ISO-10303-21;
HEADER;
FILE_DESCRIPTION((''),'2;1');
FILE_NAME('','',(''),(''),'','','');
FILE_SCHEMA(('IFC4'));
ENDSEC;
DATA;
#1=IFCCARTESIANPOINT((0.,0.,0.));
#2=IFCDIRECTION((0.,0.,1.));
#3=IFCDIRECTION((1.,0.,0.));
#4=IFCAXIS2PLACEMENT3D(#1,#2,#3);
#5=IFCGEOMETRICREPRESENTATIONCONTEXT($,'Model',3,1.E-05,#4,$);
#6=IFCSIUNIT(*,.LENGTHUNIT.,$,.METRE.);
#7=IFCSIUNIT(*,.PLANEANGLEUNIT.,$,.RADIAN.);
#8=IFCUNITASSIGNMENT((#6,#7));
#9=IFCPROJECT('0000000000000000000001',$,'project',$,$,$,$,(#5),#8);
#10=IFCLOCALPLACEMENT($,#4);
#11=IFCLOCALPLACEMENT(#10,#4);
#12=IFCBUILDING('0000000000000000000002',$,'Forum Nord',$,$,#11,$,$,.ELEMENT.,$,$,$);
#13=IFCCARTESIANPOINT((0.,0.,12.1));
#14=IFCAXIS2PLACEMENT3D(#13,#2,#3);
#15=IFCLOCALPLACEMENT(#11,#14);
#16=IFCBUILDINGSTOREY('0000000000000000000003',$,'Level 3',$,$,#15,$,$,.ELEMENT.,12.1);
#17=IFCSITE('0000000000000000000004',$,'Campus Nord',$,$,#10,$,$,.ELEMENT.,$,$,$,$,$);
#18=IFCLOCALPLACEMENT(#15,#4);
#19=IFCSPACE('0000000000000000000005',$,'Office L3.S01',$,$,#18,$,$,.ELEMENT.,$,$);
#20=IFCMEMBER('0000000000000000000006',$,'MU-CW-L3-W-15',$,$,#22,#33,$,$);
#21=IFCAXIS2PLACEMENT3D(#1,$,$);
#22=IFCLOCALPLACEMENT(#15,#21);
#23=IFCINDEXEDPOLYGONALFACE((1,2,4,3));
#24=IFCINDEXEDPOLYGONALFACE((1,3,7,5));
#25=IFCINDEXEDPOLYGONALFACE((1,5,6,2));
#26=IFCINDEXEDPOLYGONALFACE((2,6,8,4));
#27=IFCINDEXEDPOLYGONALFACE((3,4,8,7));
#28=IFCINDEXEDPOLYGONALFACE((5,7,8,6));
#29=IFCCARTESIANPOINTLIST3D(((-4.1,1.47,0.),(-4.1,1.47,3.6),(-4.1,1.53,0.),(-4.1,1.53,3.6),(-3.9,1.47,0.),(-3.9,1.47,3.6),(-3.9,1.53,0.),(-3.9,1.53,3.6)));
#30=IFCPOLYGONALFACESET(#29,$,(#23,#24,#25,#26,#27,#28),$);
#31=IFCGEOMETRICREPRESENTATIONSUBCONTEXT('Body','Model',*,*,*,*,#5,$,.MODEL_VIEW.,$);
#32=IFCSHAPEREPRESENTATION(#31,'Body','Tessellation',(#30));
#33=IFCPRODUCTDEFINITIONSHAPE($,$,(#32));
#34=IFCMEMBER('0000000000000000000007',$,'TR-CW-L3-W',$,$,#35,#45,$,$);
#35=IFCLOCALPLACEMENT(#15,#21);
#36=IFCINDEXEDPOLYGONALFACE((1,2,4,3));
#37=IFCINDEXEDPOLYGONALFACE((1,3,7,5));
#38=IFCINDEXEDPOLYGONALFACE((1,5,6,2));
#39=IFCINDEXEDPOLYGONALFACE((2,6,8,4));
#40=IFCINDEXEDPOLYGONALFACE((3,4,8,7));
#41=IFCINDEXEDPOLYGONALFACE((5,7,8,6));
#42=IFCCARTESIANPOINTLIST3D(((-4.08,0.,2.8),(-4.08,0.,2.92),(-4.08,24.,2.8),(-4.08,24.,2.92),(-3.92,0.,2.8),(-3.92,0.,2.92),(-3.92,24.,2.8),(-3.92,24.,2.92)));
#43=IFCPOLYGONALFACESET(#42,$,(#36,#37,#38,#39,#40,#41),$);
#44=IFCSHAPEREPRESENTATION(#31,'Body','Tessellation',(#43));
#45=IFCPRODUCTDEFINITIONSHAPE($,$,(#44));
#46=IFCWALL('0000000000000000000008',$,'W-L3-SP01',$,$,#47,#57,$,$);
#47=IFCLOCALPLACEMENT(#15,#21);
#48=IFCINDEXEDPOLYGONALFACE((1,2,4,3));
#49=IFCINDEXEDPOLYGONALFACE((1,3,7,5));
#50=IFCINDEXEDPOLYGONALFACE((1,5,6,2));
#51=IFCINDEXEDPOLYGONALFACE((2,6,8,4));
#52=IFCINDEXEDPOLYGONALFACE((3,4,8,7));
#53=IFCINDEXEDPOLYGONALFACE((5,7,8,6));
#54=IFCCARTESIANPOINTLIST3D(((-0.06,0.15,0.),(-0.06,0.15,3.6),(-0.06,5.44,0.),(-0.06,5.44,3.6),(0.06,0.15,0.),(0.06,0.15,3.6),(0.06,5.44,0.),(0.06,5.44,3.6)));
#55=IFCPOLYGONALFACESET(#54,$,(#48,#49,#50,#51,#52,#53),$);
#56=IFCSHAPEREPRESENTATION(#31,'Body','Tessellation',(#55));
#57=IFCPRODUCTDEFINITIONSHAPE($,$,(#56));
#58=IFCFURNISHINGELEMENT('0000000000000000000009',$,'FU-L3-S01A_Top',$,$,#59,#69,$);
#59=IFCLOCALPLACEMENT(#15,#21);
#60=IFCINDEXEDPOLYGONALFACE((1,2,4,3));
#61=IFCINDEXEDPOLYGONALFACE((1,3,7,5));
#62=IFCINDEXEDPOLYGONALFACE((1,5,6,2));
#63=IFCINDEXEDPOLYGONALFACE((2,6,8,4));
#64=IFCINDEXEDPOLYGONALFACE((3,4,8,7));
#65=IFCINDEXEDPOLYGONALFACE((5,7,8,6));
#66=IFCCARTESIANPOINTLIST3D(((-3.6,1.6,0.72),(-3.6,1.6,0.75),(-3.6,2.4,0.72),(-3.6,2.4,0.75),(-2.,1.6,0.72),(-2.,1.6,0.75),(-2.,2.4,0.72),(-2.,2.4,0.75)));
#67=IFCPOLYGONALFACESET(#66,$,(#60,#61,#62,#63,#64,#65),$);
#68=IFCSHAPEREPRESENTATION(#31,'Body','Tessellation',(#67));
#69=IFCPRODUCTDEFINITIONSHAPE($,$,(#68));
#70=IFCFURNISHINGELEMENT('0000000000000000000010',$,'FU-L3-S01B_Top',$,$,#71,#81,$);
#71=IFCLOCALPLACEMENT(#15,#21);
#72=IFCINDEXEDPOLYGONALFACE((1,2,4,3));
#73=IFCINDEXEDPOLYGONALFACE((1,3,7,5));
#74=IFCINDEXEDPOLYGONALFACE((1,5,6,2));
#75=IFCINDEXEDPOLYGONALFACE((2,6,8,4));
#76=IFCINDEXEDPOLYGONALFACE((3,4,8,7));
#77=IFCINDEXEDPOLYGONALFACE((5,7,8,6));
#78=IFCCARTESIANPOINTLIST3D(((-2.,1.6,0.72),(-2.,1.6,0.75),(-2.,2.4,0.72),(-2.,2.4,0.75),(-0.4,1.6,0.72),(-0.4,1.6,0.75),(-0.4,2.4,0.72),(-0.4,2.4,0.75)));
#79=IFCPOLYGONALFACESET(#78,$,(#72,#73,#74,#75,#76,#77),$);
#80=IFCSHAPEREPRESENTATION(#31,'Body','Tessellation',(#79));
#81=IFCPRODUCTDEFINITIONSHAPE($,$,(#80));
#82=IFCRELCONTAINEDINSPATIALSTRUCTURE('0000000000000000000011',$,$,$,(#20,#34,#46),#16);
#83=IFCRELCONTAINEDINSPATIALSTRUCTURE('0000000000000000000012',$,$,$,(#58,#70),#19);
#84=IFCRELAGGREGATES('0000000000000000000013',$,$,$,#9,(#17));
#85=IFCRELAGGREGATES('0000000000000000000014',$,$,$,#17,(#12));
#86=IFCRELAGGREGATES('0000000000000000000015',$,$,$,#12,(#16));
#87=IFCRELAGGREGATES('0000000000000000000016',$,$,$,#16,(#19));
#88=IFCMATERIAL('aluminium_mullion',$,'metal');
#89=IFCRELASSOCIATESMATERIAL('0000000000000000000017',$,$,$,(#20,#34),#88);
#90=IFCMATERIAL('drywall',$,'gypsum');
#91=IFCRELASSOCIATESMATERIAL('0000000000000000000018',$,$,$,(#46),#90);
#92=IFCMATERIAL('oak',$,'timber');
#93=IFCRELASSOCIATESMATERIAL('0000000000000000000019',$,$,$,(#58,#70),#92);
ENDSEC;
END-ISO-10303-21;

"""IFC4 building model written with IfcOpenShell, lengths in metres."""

from ifc_helpers import new_model, si_unit, frame, frame_2d, origin_with_axes, place, context, subcontext, project, spatial, polyline, rectangle, outline, extrude, material, element, save


model = new_model("IFC4")

# Units and contexts
model_context = context("Model", 3, precision=1e-05, world=origin_with_axes())
body_context = subcontext(model_context, "Body", "Model", "MODEL_VIEW")
ifc_project = project(units=[si_unit("LENGTHUNIT", "METRE"), si_unit("PLANEANGLEUNIT", "RADIAN")], contexts=[model_context])

# Site, building, storey
site_placement = place(None, origin_with_axes())
site = spatial("IfcSite", under=ifc_project, at=site_placement, Name="Campus Nord", CompositionType="ELEMENT")
building_placement = place(site_placement, origin_with_axes())
building = spatial("IfcBuilding", under=site, at=building_placement, Name="Forum Nord", CompositionType="ELEMENT")
storey_placement = place(building_placement, frame((0.0, 0.0, 12.1), z_axis=(0.0, 0.0, 1.0), x_axis=(1.0, 0.0, 0.0)))
storey = spatial("IfcBuildingStorey", under=building, at=storey_placement, Name="Level 3", CompositionType="ELEMENT", Elevation=12.1)

# Members
ifc_material_1 = material(Name="aluminium_mullion", Category="metal")
member_1_placement = place(storey_placement, origin_with_axes())
element("IfcMember", 1, at=member_1_placement, inside=storey, material=ifc_material_1, Name="MU-CW-L3-W-15", context=body_context, shape_type="SweptSolid", body=[
    extrude(outline(polyline([(-4.1, 1.53), (-4.1, 1.47), (-3.9, 1.47), (-3.9, 1.53), (-4.1, 1.53)])), origin_with_axes(), (0.0, 0.0, 1.0), 3.6),
])
member_2_placement = place(storey_placement, frame((0.0, 0.0, 2.8), z_axis=(0.0, 0.0, 1.0), x_axis=(1.0, 0.0, 0.0)))
element("IfcMember", 2, at=member_2_placement, inside=storey, material=ifc_material_1, Name="TR-CW-L3-W", context=body_context, shape_type="SweptSolid", body=[
    extrude(outline(polyline([(-4.08, 24.0), (-4.08, 0.0), (-3.92, 0.0), (-3.92, 24.0), (-4.08, 24.0)])), origin_with_axes(), (0.0, 0.0, 1.0), 0.12),
])

# Wall
ifc_material_2 = material(Name="drywall", Category="gypsum")
wall_placement = place(storey_placement, frame((0.0, 0.0, 0.0), z_axis=(0.0, 0.0, 1.0), x_axis=(0.0, 1.0, 0.0)))
element("IfcWall", 3, at=wall_placement, inside=storey, material=ifc_material_2, Name="W-L3-SP01", context=body_context, shape_type="SweptSolid", body=[
    extrude(outline(polyline([(0.15, -0.06), (5.44, -0.06), (5.44, 0.06), (0.15, 0.06), (0.15, -0.06)])), origin_with_axes(), (0.0, 0.0, 1.0), 3.6),
])

# Shared definitions
space_placement = place(storey_placement, origin_with_axes())
space = spatial("IfcSpace", under=storey, at=space_placement, Name="Office L3.S01", CompositionType="ELEMENT")

# Furnishing elements
ifc_material_3 = material(Name="oak", Category="timber")
furnishing_1_placement = place(storey_placement, frame((-3.6, 1.0, 0.0), z_axis=(0.0, 0.0, 1.0), x_axis=(1.0, 0.0, 0.0)))
element("IfcFurnishingElement", 4, at=furnishing_1_placement, inside=space, material=ifc_material_3, Name="FU-L3-S01A_Top", context=body_context, shape_type="SweptSolid", body=[
    extrude(rectangle(XDim=1.6, YDim=0.8, at=frame_2d((0.8, 1.0), x_axis=(1.0, 0.0))), frame((0.0, 0.0, 0.72), z_axis=(0.0, 0.0, 1.0), x_axis=(1.0, 0.0, 0.0)), (0.0, 0.0, 1.0), 0.03),
])
furnishing_2_placement = place(storey_placement, frame((-2.0, 1.0, 0.0), z_axis=(0.0, 0.0, 1.0), x_axis=(1.0, 0.0, 0.0)))
element("IfcFurnishingElement", 5, at=furnishing_2_placement, inside=space, material=ifc_material_3, Name="FU-L3-S01B_Top", context=body_context, shape_type="SweptSolid", body=[
    extrude(rectangle(XDim=1.6, YDim=0.8, at=frame_2d((0.8, 1.0), x_axis=(1.0, 0.0))), frame((0.0, 0.0, 0.72), z_axis=(0.0, 0.0, 1.0), x_axis=(1.0, 0.0, 0.0)), (0.0, 0.0, 1.0), 0.03),
])

save(model, "model.ifc")
